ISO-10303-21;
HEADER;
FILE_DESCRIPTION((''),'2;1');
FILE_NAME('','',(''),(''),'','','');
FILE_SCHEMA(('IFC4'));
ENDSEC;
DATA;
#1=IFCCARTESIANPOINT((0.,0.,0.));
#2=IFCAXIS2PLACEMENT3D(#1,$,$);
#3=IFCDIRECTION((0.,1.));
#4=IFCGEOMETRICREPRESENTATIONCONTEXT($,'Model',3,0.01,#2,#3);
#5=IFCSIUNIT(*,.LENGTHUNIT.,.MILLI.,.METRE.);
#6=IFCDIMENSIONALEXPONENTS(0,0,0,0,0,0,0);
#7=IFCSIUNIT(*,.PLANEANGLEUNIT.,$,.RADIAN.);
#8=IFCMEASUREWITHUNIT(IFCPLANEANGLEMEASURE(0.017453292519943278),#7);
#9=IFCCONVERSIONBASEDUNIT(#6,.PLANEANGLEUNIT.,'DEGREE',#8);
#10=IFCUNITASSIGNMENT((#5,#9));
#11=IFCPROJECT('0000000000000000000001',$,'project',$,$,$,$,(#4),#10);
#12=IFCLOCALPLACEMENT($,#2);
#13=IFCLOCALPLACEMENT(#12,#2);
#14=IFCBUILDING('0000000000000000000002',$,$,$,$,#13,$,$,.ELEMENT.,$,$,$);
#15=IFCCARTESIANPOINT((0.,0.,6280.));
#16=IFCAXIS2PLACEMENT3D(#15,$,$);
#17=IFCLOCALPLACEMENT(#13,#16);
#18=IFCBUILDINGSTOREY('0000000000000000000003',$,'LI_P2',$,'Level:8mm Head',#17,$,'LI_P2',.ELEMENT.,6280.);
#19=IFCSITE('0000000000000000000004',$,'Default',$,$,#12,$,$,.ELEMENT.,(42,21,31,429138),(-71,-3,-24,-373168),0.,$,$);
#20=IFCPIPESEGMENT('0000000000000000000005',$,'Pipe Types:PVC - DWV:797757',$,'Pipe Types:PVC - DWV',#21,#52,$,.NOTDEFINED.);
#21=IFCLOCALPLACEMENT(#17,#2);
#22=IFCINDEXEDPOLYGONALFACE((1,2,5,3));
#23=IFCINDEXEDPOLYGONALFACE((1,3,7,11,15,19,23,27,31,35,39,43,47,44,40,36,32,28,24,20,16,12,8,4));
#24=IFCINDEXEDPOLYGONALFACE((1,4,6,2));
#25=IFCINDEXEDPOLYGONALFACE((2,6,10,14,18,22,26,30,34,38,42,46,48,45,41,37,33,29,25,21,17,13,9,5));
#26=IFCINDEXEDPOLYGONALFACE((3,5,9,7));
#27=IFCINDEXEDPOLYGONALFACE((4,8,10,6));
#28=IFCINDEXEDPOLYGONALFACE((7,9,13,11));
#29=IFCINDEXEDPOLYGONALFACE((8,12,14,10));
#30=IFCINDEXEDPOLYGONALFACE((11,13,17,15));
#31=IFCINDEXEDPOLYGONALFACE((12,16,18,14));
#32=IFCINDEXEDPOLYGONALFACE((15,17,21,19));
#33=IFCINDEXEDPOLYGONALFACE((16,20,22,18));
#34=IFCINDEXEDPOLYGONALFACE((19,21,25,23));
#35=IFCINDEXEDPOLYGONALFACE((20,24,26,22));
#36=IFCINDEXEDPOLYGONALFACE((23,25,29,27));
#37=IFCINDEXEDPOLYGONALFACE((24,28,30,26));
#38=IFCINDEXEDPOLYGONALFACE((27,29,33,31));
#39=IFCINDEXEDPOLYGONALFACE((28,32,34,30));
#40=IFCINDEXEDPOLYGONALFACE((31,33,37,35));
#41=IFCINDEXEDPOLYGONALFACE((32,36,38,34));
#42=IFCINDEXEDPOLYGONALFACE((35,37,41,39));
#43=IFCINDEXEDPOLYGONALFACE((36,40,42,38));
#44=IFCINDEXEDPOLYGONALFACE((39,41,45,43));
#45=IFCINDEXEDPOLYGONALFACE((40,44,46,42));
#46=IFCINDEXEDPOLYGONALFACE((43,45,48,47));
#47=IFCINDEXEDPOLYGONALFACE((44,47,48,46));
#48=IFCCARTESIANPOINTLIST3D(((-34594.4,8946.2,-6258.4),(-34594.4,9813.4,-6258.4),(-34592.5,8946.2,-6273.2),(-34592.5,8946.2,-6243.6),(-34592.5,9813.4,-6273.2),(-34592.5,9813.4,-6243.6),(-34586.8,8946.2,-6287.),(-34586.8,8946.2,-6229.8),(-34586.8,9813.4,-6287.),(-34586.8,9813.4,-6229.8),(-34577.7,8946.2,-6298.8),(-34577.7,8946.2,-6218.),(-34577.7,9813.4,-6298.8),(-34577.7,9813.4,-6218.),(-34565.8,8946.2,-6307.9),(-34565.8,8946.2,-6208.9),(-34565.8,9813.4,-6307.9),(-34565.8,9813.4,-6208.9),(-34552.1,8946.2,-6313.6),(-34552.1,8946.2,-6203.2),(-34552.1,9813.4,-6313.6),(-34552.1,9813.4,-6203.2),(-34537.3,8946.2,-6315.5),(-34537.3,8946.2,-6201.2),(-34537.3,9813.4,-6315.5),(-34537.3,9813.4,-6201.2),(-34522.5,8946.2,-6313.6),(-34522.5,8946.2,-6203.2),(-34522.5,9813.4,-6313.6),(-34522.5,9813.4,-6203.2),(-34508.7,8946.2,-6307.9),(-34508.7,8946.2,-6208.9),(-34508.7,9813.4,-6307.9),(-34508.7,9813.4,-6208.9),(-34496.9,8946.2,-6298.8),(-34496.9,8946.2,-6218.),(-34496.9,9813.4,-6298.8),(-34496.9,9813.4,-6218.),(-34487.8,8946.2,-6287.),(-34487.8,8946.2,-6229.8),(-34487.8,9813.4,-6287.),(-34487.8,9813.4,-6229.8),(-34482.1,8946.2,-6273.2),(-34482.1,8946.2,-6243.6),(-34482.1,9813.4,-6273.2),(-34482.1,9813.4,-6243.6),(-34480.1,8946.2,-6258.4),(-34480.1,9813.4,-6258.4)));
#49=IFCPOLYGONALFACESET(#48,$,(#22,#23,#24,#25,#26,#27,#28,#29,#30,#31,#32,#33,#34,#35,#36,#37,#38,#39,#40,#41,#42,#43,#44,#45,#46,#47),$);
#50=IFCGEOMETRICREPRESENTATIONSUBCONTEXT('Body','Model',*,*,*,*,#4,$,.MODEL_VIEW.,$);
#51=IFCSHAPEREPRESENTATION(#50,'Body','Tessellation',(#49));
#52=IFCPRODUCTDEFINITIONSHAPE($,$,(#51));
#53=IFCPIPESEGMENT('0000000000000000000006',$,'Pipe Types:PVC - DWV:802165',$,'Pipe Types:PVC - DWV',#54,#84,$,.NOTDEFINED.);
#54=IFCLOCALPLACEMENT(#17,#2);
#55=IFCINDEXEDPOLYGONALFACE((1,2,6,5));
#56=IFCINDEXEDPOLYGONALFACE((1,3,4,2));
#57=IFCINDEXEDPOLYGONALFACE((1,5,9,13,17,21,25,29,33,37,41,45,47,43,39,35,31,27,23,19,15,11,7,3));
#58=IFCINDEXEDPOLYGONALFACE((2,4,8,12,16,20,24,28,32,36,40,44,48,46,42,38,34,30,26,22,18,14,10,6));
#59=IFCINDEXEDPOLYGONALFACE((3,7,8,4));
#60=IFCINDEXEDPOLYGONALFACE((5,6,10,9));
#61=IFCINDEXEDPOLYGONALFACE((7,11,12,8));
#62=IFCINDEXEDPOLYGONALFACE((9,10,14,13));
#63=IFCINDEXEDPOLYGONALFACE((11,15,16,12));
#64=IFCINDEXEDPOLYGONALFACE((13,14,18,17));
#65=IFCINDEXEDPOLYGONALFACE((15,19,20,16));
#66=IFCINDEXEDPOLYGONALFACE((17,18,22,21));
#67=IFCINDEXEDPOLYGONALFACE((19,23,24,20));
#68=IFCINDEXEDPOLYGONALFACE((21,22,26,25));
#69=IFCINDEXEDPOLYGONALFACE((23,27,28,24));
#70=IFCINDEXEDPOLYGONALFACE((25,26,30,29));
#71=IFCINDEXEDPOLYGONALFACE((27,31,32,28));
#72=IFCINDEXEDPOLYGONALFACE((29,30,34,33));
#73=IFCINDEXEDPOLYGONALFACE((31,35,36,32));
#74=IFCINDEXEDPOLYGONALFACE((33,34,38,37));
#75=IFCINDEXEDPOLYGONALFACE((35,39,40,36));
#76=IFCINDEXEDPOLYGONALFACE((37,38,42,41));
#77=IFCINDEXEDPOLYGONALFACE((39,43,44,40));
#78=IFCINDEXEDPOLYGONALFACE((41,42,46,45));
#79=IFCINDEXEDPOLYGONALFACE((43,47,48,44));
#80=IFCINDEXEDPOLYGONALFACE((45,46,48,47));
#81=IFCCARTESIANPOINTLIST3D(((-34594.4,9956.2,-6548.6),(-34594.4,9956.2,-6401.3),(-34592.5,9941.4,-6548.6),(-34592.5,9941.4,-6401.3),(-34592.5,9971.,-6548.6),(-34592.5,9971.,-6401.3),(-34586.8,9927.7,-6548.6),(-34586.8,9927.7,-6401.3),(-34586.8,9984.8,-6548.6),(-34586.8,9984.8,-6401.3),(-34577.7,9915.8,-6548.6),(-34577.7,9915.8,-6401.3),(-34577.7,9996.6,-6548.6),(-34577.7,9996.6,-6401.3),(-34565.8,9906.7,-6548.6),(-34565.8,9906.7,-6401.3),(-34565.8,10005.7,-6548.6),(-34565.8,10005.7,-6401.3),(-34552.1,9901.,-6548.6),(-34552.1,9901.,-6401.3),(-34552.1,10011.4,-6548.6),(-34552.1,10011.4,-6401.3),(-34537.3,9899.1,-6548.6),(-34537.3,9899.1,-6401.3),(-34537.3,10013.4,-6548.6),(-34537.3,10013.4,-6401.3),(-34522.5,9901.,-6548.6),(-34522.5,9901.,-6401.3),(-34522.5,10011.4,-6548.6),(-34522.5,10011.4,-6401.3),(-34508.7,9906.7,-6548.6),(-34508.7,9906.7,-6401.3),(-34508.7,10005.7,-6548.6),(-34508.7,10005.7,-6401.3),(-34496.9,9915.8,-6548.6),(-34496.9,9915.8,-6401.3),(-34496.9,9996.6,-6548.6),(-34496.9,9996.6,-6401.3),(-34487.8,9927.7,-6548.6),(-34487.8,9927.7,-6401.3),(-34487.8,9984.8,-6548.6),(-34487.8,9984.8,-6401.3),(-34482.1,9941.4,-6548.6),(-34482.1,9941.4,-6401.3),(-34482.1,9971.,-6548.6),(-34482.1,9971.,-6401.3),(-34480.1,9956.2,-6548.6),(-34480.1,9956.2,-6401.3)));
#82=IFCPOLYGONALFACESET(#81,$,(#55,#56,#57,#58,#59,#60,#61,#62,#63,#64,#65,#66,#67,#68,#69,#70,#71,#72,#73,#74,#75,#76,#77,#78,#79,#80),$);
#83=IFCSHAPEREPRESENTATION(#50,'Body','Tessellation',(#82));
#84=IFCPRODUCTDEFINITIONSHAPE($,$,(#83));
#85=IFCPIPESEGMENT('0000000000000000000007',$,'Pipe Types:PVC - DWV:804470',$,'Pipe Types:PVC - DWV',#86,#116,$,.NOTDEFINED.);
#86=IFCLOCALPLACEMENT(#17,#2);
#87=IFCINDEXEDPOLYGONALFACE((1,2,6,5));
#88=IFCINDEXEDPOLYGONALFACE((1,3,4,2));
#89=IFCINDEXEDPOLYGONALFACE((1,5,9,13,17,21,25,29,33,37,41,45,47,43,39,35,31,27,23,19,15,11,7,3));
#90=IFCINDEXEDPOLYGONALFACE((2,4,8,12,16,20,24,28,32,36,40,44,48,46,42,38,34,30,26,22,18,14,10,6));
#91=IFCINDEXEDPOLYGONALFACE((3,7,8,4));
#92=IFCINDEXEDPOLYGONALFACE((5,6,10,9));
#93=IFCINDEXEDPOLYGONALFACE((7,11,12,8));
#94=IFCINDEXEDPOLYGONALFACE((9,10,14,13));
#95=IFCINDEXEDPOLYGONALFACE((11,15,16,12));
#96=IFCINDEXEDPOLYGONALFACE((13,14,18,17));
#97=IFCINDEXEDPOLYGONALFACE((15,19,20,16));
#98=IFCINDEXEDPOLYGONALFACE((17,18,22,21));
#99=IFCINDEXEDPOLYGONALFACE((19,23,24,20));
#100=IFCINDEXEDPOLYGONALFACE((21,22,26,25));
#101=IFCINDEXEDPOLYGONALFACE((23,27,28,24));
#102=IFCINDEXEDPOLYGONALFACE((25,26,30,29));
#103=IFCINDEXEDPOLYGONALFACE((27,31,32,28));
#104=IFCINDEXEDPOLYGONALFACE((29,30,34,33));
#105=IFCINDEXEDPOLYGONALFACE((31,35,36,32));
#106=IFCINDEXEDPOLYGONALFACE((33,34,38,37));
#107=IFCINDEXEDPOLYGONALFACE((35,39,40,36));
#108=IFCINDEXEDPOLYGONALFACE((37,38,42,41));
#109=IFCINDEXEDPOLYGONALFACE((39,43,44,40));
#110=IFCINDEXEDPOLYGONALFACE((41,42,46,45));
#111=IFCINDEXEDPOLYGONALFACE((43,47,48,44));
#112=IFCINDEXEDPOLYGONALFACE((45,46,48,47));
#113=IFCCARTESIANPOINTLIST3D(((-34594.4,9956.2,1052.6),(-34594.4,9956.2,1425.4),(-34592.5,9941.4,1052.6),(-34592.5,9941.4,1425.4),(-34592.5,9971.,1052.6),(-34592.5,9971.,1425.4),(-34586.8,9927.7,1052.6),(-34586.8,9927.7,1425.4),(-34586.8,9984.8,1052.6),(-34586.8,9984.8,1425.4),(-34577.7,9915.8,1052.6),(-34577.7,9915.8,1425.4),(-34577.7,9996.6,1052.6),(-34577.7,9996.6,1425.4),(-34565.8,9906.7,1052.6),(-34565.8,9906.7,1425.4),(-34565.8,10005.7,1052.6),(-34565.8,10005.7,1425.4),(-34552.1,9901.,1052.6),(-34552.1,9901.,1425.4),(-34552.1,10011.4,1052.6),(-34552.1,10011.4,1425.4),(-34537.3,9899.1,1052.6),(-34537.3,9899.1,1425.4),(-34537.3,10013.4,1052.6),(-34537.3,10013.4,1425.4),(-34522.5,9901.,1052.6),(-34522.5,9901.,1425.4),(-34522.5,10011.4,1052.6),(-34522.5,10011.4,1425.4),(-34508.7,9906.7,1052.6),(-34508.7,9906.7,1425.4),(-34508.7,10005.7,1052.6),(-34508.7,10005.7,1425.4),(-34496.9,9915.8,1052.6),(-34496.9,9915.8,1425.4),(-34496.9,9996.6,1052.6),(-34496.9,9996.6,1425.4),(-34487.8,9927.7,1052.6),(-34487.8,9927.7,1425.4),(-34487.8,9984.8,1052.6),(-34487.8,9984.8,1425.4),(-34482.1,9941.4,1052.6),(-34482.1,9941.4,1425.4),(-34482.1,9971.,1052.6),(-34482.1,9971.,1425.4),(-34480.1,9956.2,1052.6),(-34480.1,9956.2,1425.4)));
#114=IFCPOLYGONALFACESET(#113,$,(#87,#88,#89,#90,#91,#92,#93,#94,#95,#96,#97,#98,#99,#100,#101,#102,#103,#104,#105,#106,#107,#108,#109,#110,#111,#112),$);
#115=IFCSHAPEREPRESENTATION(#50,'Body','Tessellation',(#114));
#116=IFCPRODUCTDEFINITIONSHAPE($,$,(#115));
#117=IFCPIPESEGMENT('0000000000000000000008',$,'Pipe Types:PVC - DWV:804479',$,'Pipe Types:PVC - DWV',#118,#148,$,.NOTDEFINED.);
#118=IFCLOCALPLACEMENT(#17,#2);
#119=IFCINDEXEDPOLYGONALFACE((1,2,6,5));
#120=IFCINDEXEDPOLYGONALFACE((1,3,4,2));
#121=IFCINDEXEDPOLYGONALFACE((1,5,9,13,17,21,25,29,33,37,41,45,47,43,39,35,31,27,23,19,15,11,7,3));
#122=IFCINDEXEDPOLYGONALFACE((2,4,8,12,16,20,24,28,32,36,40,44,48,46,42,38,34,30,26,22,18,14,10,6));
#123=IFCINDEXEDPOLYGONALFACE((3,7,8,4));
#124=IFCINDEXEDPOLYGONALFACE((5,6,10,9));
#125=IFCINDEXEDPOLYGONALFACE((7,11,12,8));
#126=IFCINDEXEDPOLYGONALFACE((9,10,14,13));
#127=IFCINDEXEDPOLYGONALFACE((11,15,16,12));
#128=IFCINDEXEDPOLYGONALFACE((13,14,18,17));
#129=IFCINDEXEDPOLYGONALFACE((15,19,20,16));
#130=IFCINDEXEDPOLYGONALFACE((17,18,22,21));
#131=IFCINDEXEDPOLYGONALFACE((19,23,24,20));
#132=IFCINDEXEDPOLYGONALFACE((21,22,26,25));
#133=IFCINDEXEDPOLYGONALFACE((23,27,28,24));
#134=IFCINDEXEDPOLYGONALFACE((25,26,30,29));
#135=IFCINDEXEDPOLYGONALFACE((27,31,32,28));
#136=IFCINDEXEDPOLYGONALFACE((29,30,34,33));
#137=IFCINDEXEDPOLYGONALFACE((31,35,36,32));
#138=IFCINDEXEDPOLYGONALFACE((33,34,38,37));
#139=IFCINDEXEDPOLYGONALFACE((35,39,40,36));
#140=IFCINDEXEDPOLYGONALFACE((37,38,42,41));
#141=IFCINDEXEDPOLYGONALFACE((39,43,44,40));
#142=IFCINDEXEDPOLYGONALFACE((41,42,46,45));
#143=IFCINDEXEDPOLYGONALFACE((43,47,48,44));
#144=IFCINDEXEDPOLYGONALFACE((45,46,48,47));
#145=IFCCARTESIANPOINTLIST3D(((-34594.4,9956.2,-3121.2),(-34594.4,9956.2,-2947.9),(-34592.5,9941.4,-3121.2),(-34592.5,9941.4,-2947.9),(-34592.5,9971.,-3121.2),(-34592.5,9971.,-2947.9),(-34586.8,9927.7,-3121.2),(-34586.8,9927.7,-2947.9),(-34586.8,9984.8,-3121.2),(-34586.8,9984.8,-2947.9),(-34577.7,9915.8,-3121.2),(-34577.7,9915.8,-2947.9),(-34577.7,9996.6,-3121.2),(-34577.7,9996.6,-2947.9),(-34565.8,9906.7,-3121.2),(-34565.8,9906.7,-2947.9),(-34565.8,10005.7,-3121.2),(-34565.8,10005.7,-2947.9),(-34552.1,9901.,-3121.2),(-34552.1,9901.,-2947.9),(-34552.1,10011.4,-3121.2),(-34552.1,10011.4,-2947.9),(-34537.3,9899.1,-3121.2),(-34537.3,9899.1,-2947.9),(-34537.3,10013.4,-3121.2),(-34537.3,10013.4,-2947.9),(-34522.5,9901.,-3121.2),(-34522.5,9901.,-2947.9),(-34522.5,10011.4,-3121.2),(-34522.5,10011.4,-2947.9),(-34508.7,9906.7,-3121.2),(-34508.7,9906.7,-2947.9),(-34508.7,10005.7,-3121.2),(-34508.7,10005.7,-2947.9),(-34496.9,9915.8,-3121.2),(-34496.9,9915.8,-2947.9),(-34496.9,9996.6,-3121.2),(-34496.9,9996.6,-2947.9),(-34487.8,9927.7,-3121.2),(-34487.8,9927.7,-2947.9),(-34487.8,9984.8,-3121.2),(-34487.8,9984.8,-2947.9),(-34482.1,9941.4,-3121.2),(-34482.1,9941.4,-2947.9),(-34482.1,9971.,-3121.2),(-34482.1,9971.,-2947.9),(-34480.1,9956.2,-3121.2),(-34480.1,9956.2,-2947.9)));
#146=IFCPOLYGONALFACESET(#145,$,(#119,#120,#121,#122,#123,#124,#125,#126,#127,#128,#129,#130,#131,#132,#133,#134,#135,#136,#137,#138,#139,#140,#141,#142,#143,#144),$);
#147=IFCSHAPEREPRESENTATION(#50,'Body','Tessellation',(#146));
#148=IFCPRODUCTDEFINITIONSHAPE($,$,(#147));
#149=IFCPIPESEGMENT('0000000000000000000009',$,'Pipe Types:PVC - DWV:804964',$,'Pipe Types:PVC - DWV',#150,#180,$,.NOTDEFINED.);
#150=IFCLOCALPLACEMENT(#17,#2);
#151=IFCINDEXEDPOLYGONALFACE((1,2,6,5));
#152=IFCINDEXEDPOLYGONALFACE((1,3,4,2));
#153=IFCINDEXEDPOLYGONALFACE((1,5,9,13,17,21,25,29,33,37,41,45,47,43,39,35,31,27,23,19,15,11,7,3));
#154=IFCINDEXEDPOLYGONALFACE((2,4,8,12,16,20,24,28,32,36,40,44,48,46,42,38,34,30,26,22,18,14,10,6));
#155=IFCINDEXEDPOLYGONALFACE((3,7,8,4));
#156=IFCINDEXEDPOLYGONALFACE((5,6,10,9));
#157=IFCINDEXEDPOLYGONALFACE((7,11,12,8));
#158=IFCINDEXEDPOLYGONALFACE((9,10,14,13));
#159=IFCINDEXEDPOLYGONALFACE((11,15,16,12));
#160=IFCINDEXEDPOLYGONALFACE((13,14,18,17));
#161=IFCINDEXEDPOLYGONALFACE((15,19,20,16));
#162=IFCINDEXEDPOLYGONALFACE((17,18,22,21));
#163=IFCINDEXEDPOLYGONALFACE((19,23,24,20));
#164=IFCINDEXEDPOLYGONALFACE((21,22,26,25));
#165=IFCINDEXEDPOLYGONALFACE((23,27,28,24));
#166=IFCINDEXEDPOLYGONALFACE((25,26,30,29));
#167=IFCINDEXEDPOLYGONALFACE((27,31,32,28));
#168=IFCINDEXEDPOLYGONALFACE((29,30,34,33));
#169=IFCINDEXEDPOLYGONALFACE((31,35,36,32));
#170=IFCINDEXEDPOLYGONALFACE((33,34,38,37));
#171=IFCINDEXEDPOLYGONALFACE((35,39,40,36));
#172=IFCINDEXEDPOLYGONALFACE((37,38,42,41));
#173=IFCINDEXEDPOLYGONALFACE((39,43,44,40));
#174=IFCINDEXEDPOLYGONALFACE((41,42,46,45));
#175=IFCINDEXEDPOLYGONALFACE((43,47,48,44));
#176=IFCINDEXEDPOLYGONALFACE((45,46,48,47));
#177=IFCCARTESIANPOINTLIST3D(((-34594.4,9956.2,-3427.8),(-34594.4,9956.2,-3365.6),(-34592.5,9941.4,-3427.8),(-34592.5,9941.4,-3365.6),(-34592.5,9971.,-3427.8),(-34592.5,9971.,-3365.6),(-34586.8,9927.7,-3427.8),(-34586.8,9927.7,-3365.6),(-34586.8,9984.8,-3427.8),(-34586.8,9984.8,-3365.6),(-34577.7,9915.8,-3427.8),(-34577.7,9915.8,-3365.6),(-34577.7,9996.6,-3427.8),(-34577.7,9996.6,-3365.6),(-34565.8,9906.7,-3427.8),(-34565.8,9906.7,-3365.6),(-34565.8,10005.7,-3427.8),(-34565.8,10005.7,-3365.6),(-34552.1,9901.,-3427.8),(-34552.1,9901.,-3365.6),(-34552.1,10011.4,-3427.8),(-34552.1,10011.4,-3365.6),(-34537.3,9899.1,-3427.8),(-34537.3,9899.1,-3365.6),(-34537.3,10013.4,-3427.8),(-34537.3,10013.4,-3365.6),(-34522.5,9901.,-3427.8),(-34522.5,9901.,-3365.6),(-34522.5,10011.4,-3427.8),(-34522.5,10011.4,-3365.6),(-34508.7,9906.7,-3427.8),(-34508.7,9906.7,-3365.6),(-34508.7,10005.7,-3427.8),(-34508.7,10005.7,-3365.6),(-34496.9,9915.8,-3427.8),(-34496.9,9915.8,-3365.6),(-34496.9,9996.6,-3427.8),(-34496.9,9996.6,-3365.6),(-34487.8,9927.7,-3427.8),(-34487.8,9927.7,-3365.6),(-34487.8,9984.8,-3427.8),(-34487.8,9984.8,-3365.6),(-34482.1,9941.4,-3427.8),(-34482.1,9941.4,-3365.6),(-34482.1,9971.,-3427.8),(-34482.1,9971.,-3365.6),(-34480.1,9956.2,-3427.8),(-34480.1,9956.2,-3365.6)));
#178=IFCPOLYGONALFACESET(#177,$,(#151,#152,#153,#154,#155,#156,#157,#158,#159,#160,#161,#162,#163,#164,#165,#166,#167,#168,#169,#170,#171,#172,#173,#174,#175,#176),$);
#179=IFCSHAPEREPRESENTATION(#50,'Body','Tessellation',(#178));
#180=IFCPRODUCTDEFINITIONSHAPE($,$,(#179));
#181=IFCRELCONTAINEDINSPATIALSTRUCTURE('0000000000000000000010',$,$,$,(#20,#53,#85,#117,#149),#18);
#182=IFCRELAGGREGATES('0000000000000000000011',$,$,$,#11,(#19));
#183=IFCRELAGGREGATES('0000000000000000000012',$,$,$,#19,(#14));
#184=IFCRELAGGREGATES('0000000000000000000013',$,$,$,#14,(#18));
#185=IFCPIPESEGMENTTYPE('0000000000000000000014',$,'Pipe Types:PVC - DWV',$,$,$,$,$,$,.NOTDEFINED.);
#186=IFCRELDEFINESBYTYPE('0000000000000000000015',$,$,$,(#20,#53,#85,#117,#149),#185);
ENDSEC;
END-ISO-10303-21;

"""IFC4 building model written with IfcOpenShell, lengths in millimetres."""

from ifc_helpers import new_model, entity, si_unit, converted_unit, direction, frame, origin, place, context, subcontext, project, spatial, arc, indexed_curve, outline, extrude, type_object, element, save


model = new_model("IFC4")

# Units and contexts
model_context = context("Model", 3, precision=0.01, world=origin(), true_north=direction((0.0, 1.0)))
body_context = subcontext(model_context, "Body", "Model", "MODEL_VIEW")
ifc_project = project(units=[si_unit("LENGTHUNIT", "METRE", prefix="MILLI"), converted_unit("PLANEANGLEUNIT", "DEGREE", entity("IfcPlaneAngleMeasure", 0.017453292519943278), si_unit("PLANEANGLEUNIT", "RADIAN"), dimensions=[0, 0, 0, 0, 0, 0, 0])], contexts=[model_context])

# Site, building, storey
site_placement = place(None, origin())
site = spatial("IfcSite", under=ifc_project, at=site_placement, Name="Default", CompositionType="ELEMENT", RefLatitude=(42, 21, 31, 429138), RefLongitude=(-71, -3, -24, -373168), RefElevation=0.0)
building_placement = place(site_placement, origin())
building = spatial("IfcBuilding", under=site, at=building_placement, CompositionType="ELEMENT")
storey_placement = place(building_placement, frame((0.0, 0.0, 6280.0)))
storey = spatial("IfcBuildingStorey", under=building, at=storey_placement, Name="LI_P2", ObjectType="Level:8mm Head", LongName="LI_P2", CompositionType="ELEMENT", Elevation=6280.0)

# Pipe segments
pipe_segment_type = type_object("IfcPipeSegmentType", Name="Pipe Types:PVC - DWV", PredefinedType="NOTDEFINED")
pipe_segment_1_placement = place(storey_placement, origin())
element("IfcPipeSegment", 1, at=pipe_segment_1_placement, inside=storey, type_object=pipe_segment_type, Name="Pipe Types:PVC - DWV:797757", ObjectType="Pipe Types:PVC - DWV", PredefinedType="NOTDEFINED", context=body_context, shape_type="SweptSolid", body=[
    extrude(outline(indexed_curve([(57.2, 0.0), (40.4, 40.4), (0.0, 57.1), (-40.4, 40.4), (-57.2, 0.0), (-40.4, -40.4), (0.0, -57.2), (40.4, -40.4)], segments=[arc(1, 2, 3), arc(3, 4, 5), arc(5, 6, 7), arc(7, 8, 1)], self_intersect=False)), frame((-34537.3, 8946.2, -6258.4), z_axis=(0.0, 1.0, 0.0), x_axis=(1.0, 0.0, 0.0)), (0.0, 0.0, 1.0), 867.2),
])
pipe_segment_2_placement = place(storey_placement, origin())
element("IfcPipeSegment", 2, at=pipe_segment_2_placement, inside=storey, type_object=pipe_segment_type, Name="Pipe Types:PVC - DWV:802165", ObjectType="Pipe Types:PVC - DWV", PredefinedType="NOTDEFINED", context=body_context, shape_type="SweptSolid", body=[
    extrude(outline(indexed_curve([(57.2, 0.0), (40.4, 40.4), (0.0, 57.2), (-40.4, 40.4), (-57.2, 0.0), (-40.4, -40.4), (0.0, -57.2), (40.4, -40.4)], segments=[arc(1, 2, 3), arc(3, 4, 5), arc(5, 6, 7), arc(7, 8, 1)], self_intersect=False)), frame((-34537.3, 9956.2, -6548.6)), (0.0, 0.0, 1.0), 147.3),
])
pipe_segment_3_placement = place(storey_placement, origin())
element("IfcPipeSegment", 3, at=pipe_segment_3_placement, inside=storey, type_object=pipe_segment_type, Name="Pipe Types:PVC - DWV:804470", ObjectType="Pipe Types:PVC - DWV", PredefinedType="NOTDEFINED", context=body_context, shape_type="SweptSolid", body=[
    extrude(outline(indexed_curve([(57.2, 0.0), (40.4, 40.4), (0.0, 57.2), (-40.4, 40.4), (-57.2, 0.0), (-40.4, -40.4), (0.0, -57.2), (40.4, -40.4)], segments=[arc(1, 2, 3), arc(3, 4, 5), arc(5, 6, 7), arc(7, 8, 1)], self_intersect=False)), frame((-34537.3, 9956.2, 1052.6), z_axis=(0.0, 0.0, 1.0), x_axis=(-1.0, 0.0, 0.0)), (0.0, 0.0, 1.0), 372.8),
])
pipe_segment_4_placement = place(storey_placement, origin())
element("IfcPipeSegment", 4, at=pipe_segment_4_placement, inside=storey, type_object=pipe_segment_type, Name="Pipe Types:PVC - DWV:804479", ObjectType="Pipe Types:PVC - DWV", PredefinedType="NOTDEFINED", context=body_context, shape_type="SweptSolid", body=[
    extrude(outline(indexed_curve([(57.2, 0.0), (40.4, 40.4), (0.0, 57.2), (-40.4, 40.4), (-57.2, 0.0), (-40.4, -40.4), (0.0, -57.2), (40.4, -40.4)], segments=[arc(1, 2, 3), arc(3, 4, 5), arc(5, 6, 7), arc(7, 8, 1)], self_intersect=False)), frame((-34537.3, 9956.2, -3121.2), z_axis=(0.0, 0.0, 1.0), x_axis=(-1.0, 0.0, 0.0)), (0.0, 0.0, 1.0), 173.2),
])
pipe_segment_5_placement = place(storey_placement, origin())
element("IfcPipeSegment", 5, at=pipe_segment_5_placement, inside=storey, type_object=pipe_segment_type, Name="Pipe Types:PVC - DWV:804964", ObjectType="Pipe Types:PVC - DWV", PredefinedType="NOTDEFINED", context=body_context, shape_type="SweptSolid", body=[
    extrude(outline(indexed_curve([(57.2, 0.0), (40.4, 40.4), (0.0, 57.2), (-40.4, 40.4), (-57.2, 0.0), (-40.4, -40.4), (0.0, -57.2), (40.4, -40.4)], segments=[arc(1, 2, 3), arc(3, 4, 5), arc(5, 6, 7), arc(7, 8, 1)], self_intersect=False)), frame((-34537.3, 9956.2, -3427.8), z_axis=(0.0, 0.0, 1.0), x_axis=(-1.0, 0.0, 0.0)), (0.0, 0.0, 1.0), 62.2),
])

save(model, "model.ifc")
